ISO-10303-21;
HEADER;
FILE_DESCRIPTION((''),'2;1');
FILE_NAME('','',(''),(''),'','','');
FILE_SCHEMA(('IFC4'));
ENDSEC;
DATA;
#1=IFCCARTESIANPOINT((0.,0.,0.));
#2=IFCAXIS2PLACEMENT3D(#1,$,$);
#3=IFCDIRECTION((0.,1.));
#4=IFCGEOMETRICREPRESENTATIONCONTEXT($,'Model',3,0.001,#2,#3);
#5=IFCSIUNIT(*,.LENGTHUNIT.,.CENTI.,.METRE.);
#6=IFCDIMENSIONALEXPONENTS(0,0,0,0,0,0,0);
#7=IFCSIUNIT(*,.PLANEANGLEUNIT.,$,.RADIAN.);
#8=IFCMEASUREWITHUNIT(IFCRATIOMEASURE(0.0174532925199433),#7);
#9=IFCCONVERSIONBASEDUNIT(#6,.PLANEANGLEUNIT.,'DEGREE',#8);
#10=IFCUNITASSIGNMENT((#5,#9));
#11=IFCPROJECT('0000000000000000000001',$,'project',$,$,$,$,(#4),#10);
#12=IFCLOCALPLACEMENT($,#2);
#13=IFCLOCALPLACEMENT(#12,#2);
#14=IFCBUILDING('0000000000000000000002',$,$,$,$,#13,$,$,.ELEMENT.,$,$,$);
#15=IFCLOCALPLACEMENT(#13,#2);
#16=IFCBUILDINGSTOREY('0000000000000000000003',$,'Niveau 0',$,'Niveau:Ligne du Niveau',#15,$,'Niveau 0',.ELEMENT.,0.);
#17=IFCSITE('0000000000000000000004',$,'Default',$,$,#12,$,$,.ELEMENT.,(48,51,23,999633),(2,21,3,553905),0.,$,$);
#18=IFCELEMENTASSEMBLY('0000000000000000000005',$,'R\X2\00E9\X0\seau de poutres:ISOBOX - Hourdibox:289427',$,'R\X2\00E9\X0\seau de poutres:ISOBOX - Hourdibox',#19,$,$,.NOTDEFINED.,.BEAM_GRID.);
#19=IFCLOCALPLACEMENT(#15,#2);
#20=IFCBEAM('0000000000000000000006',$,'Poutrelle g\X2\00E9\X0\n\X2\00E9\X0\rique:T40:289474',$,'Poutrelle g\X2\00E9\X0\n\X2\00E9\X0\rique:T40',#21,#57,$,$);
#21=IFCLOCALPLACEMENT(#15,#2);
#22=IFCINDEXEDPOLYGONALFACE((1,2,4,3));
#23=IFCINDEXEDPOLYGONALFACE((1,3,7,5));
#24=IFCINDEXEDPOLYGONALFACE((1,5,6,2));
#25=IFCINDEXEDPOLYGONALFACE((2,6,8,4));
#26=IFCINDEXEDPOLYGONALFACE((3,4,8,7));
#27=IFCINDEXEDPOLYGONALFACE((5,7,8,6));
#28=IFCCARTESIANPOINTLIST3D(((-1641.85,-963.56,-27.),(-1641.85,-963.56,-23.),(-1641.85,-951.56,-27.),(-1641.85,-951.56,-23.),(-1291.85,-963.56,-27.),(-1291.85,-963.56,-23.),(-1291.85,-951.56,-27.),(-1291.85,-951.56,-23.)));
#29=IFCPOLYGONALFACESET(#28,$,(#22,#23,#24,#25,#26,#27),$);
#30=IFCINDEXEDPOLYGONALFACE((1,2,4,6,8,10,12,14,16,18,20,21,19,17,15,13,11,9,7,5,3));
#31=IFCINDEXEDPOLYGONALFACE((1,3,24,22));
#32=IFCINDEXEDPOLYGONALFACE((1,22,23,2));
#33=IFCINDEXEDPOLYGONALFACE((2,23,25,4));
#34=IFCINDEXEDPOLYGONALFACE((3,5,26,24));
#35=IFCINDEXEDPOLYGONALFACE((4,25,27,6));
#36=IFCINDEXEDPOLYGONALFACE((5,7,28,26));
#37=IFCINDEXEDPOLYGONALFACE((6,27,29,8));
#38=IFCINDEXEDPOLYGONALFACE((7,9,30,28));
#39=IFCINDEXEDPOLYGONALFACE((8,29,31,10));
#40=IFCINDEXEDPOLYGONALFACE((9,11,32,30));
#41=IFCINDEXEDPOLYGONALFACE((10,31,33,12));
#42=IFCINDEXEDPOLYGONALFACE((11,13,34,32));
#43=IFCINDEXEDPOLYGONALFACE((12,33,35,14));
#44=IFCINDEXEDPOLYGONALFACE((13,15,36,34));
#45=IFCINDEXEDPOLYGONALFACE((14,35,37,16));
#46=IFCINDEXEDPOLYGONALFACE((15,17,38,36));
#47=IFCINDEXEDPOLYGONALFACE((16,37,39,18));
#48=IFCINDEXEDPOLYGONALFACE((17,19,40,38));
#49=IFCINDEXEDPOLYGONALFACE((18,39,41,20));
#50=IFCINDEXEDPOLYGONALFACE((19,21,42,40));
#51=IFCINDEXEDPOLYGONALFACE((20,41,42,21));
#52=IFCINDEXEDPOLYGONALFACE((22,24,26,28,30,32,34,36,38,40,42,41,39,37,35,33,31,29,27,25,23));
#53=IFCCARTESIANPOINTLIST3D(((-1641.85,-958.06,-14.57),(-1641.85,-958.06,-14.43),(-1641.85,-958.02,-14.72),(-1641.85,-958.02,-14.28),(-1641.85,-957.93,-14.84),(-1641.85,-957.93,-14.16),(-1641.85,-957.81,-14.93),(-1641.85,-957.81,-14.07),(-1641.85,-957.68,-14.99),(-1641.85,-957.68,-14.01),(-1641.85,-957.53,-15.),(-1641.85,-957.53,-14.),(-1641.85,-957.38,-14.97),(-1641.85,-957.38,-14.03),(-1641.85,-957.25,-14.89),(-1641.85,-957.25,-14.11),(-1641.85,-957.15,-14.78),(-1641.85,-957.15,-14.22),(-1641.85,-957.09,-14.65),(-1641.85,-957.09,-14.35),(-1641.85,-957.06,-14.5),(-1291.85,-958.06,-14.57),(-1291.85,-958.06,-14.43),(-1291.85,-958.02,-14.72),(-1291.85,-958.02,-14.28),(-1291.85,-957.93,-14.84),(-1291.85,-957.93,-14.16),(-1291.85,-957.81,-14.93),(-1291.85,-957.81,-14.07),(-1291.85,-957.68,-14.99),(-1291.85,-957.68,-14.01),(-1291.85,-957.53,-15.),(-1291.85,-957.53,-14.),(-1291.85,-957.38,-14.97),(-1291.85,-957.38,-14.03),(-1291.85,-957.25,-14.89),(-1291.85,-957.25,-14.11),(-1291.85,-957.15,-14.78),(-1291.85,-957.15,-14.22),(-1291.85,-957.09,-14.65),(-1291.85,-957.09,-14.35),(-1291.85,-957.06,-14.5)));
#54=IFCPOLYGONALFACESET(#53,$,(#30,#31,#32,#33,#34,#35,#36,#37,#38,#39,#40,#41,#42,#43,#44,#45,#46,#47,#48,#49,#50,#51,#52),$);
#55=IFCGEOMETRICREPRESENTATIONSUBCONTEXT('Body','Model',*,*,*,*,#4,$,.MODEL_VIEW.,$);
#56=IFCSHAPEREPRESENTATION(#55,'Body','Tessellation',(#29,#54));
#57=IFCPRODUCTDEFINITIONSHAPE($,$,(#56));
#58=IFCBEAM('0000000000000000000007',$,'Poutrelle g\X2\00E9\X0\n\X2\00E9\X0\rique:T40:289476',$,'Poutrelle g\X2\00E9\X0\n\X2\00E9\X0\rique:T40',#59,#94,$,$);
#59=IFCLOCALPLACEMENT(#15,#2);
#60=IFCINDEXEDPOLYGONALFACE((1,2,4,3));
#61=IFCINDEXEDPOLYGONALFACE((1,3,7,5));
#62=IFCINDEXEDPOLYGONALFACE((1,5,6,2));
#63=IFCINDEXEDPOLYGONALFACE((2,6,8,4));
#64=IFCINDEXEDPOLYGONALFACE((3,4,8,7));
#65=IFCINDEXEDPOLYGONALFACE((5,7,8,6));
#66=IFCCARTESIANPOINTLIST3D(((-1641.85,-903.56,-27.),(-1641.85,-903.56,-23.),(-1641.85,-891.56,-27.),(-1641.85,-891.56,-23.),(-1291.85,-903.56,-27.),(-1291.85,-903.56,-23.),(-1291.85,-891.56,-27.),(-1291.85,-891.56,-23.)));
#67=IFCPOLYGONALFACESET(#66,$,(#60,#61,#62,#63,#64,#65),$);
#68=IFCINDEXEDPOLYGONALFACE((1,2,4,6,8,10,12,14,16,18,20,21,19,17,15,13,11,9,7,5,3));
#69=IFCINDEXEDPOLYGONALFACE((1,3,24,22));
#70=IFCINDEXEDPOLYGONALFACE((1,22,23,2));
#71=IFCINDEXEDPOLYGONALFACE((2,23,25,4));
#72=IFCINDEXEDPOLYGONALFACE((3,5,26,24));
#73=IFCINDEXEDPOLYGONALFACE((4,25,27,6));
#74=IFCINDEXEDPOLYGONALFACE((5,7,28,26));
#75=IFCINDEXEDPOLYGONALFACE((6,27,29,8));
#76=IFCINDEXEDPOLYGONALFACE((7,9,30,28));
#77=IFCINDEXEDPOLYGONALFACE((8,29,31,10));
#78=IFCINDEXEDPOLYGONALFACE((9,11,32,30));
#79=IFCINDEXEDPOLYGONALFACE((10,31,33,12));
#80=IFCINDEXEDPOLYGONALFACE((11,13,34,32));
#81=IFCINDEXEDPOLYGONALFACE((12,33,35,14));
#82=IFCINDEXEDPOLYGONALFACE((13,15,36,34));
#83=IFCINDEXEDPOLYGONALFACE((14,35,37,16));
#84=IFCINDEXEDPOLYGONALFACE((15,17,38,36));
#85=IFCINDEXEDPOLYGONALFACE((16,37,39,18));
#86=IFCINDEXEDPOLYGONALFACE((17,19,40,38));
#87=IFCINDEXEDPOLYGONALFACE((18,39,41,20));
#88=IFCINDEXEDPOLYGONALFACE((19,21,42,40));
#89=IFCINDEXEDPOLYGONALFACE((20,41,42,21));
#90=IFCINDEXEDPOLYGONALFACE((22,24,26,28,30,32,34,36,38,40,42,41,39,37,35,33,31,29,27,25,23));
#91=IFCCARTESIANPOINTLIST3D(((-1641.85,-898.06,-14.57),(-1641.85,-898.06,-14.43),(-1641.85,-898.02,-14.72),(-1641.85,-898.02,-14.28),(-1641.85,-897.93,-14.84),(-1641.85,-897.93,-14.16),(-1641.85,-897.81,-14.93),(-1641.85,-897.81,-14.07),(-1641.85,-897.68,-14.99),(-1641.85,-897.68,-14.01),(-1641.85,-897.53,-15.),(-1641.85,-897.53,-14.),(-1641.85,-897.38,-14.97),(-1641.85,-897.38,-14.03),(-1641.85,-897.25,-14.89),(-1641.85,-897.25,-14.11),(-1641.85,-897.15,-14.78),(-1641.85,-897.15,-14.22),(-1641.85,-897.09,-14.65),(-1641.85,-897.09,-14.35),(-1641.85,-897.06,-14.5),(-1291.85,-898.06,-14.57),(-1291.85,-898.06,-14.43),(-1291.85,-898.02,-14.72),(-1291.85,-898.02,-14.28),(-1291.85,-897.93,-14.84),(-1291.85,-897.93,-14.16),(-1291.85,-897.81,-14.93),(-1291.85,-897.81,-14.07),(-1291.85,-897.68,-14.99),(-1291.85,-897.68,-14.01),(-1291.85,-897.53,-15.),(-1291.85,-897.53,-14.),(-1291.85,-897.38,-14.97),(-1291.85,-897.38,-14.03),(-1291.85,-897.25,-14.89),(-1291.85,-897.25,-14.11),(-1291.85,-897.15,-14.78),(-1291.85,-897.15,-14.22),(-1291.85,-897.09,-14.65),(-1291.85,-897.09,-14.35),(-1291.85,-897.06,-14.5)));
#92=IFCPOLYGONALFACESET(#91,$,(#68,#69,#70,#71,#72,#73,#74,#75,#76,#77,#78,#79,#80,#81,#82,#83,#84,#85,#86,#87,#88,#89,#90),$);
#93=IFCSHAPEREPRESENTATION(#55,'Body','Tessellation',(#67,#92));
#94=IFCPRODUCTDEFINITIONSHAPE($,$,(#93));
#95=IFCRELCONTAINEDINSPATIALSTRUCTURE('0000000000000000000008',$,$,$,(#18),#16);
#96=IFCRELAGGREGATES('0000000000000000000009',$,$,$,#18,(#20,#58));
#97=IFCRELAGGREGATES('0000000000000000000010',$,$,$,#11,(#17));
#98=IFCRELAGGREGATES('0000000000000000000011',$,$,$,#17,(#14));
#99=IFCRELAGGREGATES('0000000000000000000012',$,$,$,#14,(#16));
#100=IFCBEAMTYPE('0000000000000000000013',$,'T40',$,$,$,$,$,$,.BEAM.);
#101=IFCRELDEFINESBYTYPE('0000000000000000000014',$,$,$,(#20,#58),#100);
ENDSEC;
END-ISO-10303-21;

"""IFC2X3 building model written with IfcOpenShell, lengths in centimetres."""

from ifc_helpers import new_model, entity, si_unit, converted_unit, direction, frame, frame_2d, origin, origin_2d_with_axis, place, context, subcontext, project, spatial, rectangle, circle, extrude, source, transform, mapped, type_object, type_shapes, element, aggregate, save


model = new_model("IFC2X3")

# Units and contexts
model_context = context("Model", 3, precision=0.001, world=origin(), true_north=direction((0.0, 1.0)))
body_context = subcontext(model_context, "Body", "Model", "MODEL_VIEW")
ifc_project = project(units=[si_unit("LENGTHUNIT", "METRE", prefix="CENTI"), converted_unit("PLANEANGLEUNIT", "DEGREE", entity("IfcRatioMeasure", 0.0174532925199433), si_unit("PLANEANGLEUNIT", "RADIAN"), dimensions=[0, 0, 0, 0, 0, 0, 0])], contexts=[model_context])

# Site, building, storey
site_placement = place(None, origin())
site = spatial("IfcSite", under=ifc_project, at=site_placement, Name="Default", CompositionType="ELEMENT", RefLatitude=(48, 51, 23, 999633), RefLongitude=(2, 21, 3, 553905), RefElevation=0.0)
building_placement = place(site_placement, origin())
building = spatial("IfcBuilding", under=site, at=building_placement, CompositionType="ELEMENT")
storey_placement = place(building_placement, origin())
storey = spatial("IfcBuildingStorey", under=building, at=storey_placement, Name="Niveau 0", ObjectType="Niveau:Ligne du Niveau", LongName="Niveau 0", CompositionType="ELEMENT", Elevation=0.0)

# Element assembly, beams
assembly_placement = place(storey_placement, origin())
assembly = element("IfcElementAssembly", 1, at=assembly_placement, inside=storey, Name="Réseau de poutres:ISOBOX - Hourdibox:289427", ObjectType="Réseau de poutres:ISOBOX - Hourdibox", AssemblyPlace="NOTDEFINED", PredefinedType="BEAM_GRID")
beam_type = type_object("IfcBeamType", Name="T40", PredefinedType="BEAM")
shared_shape_1 = source(origin(), body_context, "Body", "SweptSolid", [
    extrude(rectangle(XDim=4.0, YDim=12.0, at=origin_2d_with_axis()), frame((175.0, 0.0, -4.5), z_axis=(-1.0, 0.0, 0.0), x_axis=(0.0, 0.0, -1.0)), (0.0, 0.0, 1.0), 350.0),
    extrude(circle(Radius=0.5, at=frame_2d((0.0, 0.0), x_axis=(1.0, 0.0))), frame((175.0, 0.0, 6.0), z_axis=(-1.0, 0.0, 0.0), x_axis=(0.0, -1.0, 0.0)), (0.0, 0.0, 1.0), 350.0),
])
type_shapes(beam_type, [shared_shape_1])
beam_1_placement = place(assembly_placement, frame((-1466.85, -957.56, -20.5), z_axis=(0.0, 0.0, 1.0), x_axis=(-1.0, 0.0, 0.0)))
beam_1 = element("IfcBeam", 2, at=beam_1_placement, type_object=beam_type, Name="Poutrelle générique:T40:289474", ObjectType="Poutrelle générique:T40", context=body_context, shape_type="MappedRepresentation", body=[
    mapped(shared_shape_1, transform((0.0, 0.0, 0.0), scale=1.0)),
])
beam_2_placement = place(assembly_placement, frame((-1466.85, -897.56, -20.5), z_axis=(0.0, 0.0, 1.0), x_axis=(-1.0, 0.0, 0.0)))
beam_2 = element("IfcBeam", 3, at=beam_2_placement, type_object=beam_type, Name="Poutrelle générique:T40:289476", ObjectType="Poutrelle générique:T40", context=body_context, shape_type="MappedRepresentation", body=[
    mapped(shared_shape_1, transform((0.0, 0.0, 0.0), scale=1.0)),
])
aggregate(assembly, [beam_1, beam_2])

save(model, "model.ifc")
